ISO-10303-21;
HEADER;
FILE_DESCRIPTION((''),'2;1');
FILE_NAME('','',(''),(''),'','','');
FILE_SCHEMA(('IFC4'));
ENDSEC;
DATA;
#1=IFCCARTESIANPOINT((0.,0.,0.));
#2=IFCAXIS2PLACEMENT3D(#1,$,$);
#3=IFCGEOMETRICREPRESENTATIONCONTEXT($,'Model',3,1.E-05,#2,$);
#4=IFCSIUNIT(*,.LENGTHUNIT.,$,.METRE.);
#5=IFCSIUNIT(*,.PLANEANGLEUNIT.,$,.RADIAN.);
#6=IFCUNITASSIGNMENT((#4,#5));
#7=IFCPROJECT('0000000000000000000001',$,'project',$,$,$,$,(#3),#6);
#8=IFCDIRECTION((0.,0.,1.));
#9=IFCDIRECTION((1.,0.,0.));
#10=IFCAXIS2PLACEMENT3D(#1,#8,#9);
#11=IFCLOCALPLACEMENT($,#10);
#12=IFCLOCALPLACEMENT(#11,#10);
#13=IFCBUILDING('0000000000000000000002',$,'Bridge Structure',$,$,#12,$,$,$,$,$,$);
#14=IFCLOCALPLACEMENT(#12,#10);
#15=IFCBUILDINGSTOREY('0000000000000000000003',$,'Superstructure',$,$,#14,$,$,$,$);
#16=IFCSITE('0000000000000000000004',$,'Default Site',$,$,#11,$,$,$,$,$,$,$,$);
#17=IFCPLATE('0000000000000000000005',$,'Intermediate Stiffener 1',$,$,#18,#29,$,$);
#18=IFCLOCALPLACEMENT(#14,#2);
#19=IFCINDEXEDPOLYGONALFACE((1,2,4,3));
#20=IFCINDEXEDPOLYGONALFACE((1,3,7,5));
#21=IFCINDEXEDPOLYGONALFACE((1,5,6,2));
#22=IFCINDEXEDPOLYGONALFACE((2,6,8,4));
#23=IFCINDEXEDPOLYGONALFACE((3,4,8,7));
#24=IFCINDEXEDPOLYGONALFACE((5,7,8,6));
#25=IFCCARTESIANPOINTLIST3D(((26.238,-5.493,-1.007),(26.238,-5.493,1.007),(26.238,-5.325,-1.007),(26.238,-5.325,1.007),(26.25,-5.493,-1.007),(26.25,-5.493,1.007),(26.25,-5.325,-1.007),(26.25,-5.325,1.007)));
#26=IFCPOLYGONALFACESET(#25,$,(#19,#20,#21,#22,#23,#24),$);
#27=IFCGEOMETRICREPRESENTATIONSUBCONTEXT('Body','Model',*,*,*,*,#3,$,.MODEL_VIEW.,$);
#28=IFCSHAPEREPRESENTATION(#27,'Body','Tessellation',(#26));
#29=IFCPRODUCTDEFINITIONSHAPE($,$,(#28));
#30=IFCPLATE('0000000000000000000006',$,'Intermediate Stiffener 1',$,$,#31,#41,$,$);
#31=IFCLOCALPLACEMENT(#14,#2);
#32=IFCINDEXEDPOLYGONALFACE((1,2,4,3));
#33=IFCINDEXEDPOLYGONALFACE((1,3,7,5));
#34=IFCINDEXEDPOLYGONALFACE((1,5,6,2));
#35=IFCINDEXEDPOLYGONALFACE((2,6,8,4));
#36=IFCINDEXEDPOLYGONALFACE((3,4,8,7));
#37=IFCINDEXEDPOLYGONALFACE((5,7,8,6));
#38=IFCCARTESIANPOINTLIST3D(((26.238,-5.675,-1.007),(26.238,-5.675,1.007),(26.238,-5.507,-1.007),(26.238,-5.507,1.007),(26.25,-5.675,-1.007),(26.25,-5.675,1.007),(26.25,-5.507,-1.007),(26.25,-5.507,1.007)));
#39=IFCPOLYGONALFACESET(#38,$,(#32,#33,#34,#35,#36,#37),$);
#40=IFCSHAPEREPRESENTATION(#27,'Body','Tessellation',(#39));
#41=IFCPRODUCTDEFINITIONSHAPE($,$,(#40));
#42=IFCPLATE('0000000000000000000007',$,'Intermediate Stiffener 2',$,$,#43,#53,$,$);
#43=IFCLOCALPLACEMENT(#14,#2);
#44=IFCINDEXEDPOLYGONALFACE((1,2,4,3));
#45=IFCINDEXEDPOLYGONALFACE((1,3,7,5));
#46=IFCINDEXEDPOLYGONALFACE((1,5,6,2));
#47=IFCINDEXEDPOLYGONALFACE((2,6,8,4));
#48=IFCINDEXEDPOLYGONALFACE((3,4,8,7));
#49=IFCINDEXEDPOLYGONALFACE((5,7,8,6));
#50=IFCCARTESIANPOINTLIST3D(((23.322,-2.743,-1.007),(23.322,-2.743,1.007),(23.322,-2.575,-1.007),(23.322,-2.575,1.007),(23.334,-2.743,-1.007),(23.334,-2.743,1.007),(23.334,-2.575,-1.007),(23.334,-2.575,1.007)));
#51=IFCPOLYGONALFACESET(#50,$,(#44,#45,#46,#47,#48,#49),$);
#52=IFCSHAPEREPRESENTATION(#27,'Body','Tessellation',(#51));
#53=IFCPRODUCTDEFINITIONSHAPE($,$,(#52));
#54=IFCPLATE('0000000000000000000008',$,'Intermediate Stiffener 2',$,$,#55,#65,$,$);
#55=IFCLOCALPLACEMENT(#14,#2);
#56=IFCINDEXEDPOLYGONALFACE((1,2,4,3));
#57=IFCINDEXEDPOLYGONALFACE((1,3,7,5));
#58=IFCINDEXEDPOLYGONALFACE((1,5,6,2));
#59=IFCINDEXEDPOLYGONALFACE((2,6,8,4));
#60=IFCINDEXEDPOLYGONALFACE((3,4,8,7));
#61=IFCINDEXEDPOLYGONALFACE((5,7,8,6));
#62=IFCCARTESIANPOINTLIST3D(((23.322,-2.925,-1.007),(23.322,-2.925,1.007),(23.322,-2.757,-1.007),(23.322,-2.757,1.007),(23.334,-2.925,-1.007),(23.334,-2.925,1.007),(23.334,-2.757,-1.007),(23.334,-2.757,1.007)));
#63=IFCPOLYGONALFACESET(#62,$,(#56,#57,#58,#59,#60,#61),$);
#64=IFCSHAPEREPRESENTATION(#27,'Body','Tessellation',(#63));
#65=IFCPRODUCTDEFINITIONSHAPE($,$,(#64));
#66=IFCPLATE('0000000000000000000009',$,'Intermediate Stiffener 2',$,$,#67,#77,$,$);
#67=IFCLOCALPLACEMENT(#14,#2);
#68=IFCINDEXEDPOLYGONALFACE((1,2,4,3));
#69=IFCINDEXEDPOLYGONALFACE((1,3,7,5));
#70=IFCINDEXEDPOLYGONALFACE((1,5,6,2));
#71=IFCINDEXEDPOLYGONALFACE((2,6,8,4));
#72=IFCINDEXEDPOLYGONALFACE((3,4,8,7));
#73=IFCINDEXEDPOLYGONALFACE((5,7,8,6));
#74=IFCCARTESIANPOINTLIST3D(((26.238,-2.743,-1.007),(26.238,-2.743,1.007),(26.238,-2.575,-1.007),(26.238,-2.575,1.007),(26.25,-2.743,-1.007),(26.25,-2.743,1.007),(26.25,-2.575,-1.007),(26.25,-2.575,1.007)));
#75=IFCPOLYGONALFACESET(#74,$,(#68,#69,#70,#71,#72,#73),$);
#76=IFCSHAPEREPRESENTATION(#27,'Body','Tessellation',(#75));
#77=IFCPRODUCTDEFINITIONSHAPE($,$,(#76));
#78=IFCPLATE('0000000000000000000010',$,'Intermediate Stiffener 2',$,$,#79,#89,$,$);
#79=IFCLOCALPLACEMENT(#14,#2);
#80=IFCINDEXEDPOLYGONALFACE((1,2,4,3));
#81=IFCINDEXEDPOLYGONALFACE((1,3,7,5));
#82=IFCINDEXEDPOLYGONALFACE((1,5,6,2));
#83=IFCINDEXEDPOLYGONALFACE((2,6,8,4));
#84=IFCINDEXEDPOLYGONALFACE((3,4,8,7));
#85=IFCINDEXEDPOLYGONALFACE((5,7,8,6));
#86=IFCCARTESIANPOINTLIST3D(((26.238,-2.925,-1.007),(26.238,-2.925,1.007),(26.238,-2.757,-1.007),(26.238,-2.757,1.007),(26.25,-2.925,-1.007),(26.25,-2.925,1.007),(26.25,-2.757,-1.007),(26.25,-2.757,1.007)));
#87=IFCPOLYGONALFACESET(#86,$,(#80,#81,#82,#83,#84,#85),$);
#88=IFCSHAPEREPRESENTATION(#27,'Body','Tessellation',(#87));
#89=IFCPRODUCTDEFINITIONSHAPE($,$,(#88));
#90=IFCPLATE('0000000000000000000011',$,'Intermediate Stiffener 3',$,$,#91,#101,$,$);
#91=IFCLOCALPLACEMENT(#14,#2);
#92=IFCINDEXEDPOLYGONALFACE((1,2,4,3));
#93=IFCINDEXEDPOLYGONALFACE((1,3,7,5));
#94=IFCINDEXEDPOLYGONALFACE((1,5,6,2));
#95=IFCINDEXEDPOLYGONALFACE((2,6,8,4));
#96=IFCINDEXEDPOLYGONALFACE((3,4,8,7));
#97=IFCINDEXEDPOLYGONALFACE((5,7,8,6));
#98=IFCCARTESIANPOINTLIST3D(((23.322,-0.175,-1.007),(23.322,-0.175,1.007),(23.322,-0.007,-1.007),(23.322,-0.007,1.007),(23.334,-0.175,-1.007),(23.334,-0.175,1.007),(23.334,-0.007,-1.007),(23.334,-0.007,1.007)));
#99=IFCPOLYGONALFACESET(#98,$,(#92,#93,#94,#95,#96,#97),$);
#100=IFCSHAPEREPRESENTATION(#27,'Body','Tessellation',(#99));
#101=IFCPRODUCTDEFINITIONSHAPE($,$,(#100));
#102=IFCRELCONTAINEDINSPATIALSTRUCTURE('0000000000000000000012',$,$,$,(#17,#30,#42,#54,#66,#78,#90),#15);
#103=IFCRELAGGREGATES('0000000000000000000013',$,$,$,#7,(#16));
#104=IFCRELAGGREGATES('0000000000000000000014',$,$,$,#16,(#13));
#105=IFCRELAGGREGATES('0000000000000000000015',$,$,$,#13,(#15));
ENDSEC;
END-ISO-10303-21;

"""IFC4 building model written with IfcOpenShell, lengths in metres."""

from ifc_helpers import new_model, si_unit, frame, origin, origin_with_axes, origin_2d_with_axis, place, context, subcontext, project, spatial, rectangle, extrude, element, save


model = new_model("IFC4")

# Units and contexts
model_context = context("Model", 3, precision=1e-05, world=origin())
body_context = subcontext(model_context, "Body", "Model", "MODEL_VIEW")
ifc_project = project(units=[si_unit("LENGTHUNIT", "METRE"), si_unit("PLANEANGLEUNIT", "RADIAN")], contexts=[model_context])

# Site, building, storey
site_placement = place(None, origin_with_axes())
site = spatial("IfcSite", under=ifc_project, at=site_placement, Name="Default Site")
building_placement = place(site_placement, origin_with_axes())
building = spatial("IfcBuilding", under=site, at=building_placement, Name="Bridge Structure")
storey_placement = place(building_placement, origin_with_axes())
storey = spatial("IfcBuildingStorey", under=building, at=storey_placement, Name="Superstructure")

# Plates
for number, where, z_axis, x_axis, name in (
    (1, (26.244, -5.409, -1.007), (0.0, 0.0, 1.0), (1.0, 0.0, 0.0), "Intermediate Stiffener 1"),
    (2, (26.244, -5.591, -1.007), (0.0, 0.0, 1.0), (1.0, 0.0, 0.0), "Intermediate Stiffener 1"),
    (3, (23.328, -2.659, -1.007), (0.0, 0.0, 1.0), (1.0, 0.0, 0.0), "Intermediate Stiffener 2"),
    (4, (23.328, -2.841, -1.007), (0.0, 0.0, 1.0), (1.0, 0.0, 0.0), "Intermediate Stiffener 2"),
    (5, (26.244, -2.659, -1.007), (0.0, 0.0, 1.0), (1.0, 0.0, 0.0), "Intermediate Stiffener 2"),
    (6, (26.244, -2.841, -1.007), (0.0, 0.0, 1.0), (1.0, 0.0, 0.0), "Intermediate Stiffener 2"),
    (7, (23.328, -0.091, -1.007), (0.0, 0.0, 1.0), (1.0, 0.0, 0.0), "Intermediate Stiffener 3"),
):
    element("IfcPlate", number, at=place(storey_placement, frame(where, z_axis=z_axis, x_axis=x_axis)), inside=storey, Name=name, context=body_context, shape_type="SweptSolid", body=[
        extrude(rectangle(XDim=0.012, YDim=0.168, at=origin_2d_with_axis()), origin_with_axes(), (0.0, 0.0, 1.0), 2.014),
    ])

save(model, "model.ifc")
